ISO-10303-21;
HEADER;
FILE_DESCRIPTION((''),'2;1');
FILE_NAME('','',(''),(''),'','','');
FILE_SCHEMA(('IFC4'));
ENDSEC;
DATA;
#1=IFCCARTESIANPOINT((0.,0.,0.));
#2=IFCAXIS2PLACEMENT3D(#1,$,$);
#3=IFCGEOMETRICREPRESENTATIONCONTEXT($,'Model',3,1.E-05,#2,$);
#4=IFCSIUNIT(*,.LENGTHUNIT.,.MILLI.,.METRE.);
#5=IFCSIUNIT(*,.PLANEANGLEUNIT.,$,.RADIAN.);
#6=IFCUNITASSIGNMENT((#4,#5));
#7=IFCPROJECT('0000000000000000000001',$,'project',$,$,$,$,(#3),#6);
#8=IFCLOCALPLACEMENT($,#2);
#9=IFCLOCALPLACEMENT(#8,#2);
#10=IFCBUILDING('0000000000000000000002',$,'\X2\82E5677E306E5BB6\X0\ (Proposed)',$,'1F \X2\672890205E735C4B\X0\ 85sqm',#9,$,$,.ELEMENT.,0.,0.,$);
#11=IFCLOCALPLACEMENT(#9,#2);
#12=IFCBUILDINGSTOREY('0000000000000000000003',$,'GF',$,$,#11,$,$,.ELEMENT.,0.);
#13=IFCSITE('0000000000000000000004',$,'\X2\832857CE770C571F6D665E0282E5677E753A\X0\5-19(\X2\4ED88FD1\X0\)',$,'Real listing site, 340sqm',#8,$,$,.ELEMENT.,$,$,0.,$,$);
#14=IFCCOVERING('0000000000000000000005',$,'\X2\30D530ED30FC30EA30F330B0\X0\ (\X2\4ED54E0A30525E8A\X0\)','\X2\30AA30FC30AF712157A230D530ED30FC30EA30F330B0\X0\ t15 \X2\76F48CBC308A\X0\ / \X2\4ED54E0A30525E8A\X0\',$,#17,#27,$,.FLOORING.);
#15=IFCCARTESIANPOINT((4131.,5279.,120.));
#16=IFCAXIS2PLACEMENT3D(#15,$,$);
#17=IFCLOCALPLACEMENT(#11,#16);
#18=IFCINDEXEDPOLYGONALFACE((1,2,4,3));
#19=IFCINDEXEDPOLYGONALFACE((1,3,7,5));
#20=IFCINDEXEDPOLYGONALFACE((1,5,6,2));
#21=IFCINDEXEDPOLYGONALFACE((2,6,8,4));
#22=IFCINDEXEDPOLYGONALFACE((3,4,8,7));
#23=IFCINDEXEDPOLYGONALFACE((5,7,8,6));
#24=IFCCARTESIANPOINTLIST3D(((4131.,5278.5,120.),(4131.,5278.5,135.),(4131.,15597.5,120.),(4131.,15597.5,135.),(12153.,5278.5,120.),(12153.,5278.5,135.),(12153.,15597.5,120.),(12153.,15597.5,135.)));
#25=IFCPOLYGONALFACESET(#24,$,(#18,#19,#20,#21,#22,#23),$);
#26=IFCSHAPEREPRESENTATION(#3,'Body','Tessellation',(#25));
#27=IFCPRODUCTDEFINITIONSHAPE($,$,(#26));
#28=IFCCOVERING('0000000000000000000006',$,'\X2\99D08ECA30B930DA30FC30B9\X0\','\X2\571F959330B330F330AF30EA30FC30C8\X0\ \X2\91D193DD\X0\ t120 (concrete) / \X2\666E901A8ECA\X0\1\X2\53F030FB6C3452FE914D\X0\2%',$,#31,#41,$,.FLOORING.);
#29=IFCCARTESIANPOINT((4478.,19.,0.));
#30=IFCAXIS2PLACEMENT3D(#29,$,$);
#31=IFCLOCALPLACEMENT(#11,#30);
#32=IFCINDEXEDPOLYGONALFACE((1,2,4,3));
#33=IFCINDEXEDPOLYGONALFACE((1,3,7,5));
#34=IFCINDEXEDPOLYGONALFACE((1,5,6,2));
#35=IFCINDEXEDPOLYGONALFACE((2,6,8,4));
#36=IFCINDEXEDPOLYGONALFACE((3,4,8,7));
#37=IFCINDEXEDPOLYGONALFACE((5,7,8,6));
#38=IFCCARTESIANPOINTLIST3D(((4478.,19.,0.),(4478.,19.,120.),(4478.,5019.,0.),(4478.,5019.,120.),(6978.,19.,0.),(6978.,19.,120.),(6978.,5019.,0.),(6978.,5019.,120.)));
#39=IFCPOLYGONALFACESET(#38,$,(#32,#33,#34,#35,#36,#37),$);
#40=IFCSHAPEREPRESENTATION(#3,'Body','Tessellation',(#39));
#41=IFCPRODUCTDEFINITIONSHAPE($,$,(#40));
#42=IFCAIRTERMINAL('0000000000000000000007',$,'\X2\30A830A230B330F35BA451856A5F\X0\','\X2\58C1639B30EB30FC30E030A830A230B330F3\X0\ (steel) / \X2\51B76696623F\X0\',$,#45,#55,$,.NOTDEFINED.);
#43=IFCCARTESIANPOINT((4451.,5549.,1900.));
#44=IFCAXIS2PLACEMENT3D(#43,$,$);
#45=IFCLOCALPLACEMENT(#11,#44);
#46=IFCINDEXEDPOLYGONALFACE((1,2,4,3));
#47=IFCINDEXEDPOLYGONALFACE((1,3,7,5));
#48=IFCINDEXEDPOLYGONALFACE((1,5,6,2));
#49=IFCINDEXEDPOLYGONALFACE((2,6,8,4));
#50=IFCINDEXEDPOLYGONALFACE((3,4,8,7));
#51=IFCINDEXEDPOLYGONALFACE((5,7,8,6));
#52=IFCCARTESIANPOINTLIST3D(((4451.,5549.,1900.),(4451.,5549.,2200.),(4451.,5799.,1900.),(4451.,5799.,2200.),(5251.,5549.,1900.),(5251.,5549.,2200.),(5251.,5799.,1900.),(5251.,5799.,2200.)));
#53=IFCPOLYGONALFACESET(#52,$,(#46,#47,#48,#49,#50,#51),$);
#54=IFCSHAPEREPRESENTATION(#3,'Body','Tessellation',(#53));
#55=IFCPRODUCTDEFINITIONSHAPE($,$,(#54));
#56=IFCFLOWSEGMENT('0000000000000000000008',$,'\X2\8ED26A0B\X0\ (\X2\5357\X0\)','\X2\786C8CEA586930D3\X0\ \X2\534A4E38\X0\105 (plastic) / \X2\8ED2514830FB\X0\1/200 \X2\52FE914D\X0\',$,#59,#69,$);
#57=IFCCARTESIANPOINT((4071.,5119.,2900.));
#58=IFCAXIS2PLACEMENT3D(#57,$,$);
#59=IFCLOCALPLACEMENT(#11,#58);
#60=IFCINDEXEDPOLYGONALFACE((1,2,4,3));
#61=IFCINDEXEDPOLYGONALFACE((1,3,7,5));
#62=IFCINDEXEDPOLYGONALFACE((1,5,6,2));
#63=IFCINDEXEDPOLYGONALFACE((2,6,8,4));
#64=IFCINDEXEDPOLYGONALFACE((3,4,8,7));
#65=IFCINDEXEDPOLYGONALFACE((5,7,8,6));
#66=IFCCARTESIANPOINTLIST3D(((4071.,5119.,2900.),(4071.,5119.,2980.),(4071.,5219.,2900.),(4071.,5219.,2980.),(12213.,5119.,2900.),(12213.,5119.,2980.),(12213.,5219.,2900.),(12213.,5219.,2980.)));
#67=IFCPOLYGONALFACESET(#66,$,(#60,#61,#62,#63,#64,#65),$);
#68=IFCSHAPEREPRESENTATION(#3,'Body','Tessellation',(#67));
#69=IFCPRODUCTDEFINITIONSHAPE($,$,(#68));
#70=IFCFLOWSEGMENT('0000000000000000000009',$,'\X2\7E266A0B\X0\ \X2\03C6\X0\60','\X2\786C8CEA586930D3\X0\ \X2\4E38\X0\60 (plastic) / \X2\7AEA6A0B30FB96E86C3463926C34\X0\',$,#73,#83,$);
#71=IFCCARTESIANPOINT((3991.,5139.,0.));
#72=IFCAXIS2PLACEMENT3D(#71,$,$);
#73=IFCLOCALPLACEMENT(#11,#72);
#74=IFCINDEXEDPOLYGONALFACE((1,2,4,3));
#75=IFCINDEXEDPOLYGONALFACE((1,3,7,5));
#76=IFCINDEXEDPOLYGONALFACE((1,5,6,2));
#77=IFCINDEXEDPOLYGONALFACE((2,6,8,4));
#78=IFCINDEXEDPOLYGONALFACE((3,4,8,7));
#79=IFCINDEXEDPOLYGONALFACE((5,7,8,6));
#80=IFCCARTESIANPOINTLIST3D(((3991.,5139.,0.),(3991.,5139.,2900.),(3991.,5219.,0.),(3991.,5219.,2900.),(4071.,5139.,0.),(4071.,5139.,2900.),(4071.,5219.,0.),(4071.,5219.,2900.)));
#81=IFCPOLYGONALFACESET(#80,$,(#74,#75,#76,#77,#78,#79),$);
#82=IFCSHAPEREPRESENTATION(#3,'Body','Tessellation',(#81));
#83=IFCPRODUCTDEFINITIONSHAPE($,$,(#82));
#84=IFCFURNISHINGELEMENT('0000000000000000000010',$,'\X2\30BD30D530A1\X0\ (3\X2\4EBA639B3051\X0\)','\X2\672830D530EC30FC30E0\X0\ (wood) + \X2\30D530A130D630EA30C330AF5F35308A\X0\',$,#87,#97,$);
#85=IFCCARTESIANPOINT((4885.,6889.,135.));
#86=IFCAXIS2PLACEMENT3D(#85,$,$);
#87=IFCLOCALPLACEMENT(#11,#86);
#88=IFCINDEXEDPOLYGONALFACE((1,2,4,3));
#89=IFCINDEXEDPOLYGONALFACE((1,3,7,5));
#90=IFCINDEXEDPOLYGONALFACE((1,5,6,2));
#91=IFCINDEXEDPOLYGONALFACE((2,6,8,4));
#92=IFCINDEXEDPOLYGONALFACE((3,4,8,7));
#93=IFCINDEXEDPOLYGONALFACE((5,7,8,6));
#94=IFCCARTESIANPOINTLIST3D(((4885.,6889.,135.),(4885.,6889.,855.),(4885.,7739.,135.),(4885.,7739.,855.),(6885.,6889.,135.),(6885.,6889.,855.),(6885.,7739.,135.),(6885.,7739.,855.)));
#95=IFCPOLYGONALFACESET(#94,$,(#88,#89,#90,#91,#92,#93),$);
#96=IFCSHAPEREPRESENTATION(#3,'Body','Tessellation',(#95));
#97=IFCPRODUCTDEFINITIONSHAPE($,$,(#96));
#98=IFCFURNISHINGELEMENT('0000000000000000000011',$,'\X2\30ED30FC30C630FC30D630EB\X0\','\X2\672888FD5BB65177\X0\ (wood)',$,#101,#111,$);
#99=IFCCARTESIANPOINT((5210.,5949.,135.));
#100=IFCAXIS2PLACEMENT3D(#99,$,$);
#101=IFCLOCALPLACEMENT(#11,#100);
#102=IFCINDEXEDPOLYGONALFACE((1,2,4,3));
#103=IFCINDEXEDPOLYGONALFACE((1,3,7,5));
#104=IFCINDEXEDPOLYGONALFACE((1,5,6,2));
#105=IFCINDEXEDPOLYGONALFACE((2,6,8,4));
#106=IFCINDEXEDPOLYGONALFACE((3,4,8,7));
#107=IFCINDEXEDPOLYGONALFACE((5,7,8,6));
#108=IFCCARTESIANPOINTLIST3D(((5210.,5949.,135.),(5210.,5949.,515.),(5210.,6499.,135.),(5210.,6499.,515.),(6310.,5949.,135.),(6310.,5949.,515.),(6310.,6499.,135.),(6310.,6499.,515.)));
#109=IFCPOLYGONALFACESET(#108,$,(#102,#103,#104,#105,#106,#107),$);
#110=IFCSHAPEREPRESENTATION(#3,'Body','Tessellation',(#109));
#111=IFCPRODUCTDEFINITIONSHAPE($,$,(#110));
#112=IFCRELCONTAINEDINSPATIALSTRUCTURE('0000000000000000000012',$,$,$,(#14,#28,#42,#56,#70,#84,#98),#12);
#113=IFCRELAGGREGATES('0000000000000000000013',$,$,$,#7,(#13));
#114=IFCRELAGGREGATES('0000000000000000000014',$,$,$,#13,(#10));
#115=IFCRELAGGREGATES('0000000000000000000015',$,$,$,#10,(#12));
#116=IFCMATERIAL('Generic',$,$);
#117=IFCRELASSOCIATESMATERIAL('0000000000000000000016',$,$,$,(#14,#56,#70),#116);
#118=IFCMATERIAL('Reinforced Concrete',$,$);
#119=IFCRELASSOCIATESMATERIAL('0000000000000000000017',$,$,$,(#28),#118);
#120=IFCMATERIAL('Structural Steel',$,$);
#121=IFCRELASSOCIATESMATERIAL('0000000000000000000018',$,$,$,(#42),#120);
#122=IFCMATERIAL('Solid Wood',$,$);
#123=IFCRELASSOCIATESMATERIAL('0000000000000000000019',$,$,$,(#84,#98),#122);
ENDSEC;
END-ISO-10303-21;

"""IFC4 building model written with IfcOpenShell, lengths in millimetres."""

from ifc_helpers import new_model, si_unit, frame, frame_2d, origin, place, context, project, spatial, rectangle, extrude, material, element, save


model = new_model("IFC4")

# Units and contexts
model_context = context("Model", 3, precision=1e-05, world=origin())
ifc_project = project(units=[si_unit("LENGTHUNIT", "METRE", prefix="MILLI"), si_unit("PLANEANGLEUNIT", "RADIAN")], contexts=[model_context])

# Site, building, storey
site_placement = place(None, origin())
site = spatial("IfcSite", under=ifc_project, at=site_placement, Name="茨城県土浦市若松町5-19(付近)", ObjectType="Real listing site, 340sqm", CompositionType="ELEMENT", RefElevation=0.0)
building_placement = place(site_placement, origin())
building = spatial("IfcBuilding", under=site, at=building_placement, Name="若松の家 (Proposed)", ObjectType="1F 木造平屋 85sqm", CompositionType="ELEMENT", ElevationOfRefHeight=0.0, ElevationOfTerrain=0.0)
storey_placement = place(building_placement, origin())
storey = spatial("IfcBuildingStorey", under=building, at=storey_placement, Name="GF", CompositionType="ELEMENT", Elevation=0.0)

# Shared definitions
ifc_material_1 = material(Name="Solid Wood")

# Shared definitions
ifc_material_2 = material(Name="Reinforced Concrete")

# Shared definitions
ifc_material_3 = material(Name="Structural Steel")

# Coverings
ifc_material_4 = material(Name="Generic")
covering_1_placement = place(storey_placement, frame((4131.0, 5279.0, 120.0)))
element("IfcCovering", 1, at=covering_1_placement, inside=storey, material=ifc_material_4, Name="フローリング (仕上げ床)", Description="オーク無垢フローリング t15 直貼り / 仕上げ床", PredefinedType="FLOORING", context=model_context, shape_type="SweptSolid", body=[
    extrude(rectangle(XDim=8022.0, YDim=10319.0, at=frame_2d((4011.0, 5159.0))), frame((4131.0, 5279.0, 120.0)), (0.0, 0.0, 1.0), 15.0),
])
covering_2_placement = place(storey_placement, frame((4478.0, 19.0, 0.0)))
element("IfcCovering", 2, at=covering_2_placement, inside=storey, material=ifc_material_2, Name="駐車スペース", Description="土間コンクリート 金鏝 t120 (concrete) / 普通車1台・水勾配2%", PredefinedType="FLOORING", context=model_context, shape_type="SweptSolid", body=[
    extrude(rectangle(XDim=2500.0, YDim=5000.0, at=frame_2d((1250.0, 2500.0))), frame((4478.0, 19.0, 0.0)), (0.0, 0.0, 1.0), 120.0),
])

# Air terminal
air_terminal_placement = place(storey_placement, frame((4451.0, 5549.0, 1900.0)))
element("IfcAirTerminal", 3, at=air_terminal_placement, inside=storey, material=ifc_material_3, Name="エアコン室内機", Description="壁掛ルームエアコン (steel) / 冷暖房", PredefinedType="NOTDEFINED", context=model_context, shape_type="SweptSolid", body=[
    extrude(rectangle(XDim=800.0, YDim=250.0, at=frame_2d((400.0, 125.0))), frame((4451.0, 5549.0, 1900.0)), (0.0, 0.0, 1.0), 300.0),
])

# Flow segments
flow_segment_1_placement = place(storey_placement, frame((4071.0, 5119.0, 2900.0)))
element("IfcFlowSegment", 4, at=flow_segment_1_placement, inside=storey, material=ifc_material_4, Name="軒樋 (南)", Description="硬質塩ビ 半丸105 (plastic) / 軒先・1/200 勾配", context=model_context, shape_type="SweptSolid", body=[
    extrude(rectangle(XDim=8142.0, YDim=100.0, at=frame_2d((4071.0, 50.0))), frame((4071.0, 5119.0, 2900.0)), (0.0, 0.0, 1.0), 80.0),
])
flow_segment_2_placement = place(storey_placement, frame((3991.0, 5139.0, 0.0)))
element("IfcFlowSegment", 5, at=flow_segment_2_placement, inside=storey, material=ifc_material_4, Name="縦樋 φ60", Description="硬質塩ビ 丸60 (plastic) / 竪樋・雨水排水", context=model_context, shape_type="SweptSolid", body=[
    extrude(rectangle(XDim=80.0, YDim=80.0, at=frame_2d((40.0, 40.0))), frame((3991.0, 5139.0, 0.0)), (0.0, 0.0, 1.0), 2900.0),
])

# Furnishing elements
furnishing_1_placement = place(storey_placement, frame((4885.0, 6889.0, 135.0)))
element("IfcFurnishingElement", 6, at=furnishing_1_placement, inside=storey, material=ifc_material_1, Name="ソファ (3人掛け)", Description="木フレーム (wood) + ファブリック張り", context=model_context, shape_type="SweptSolid", body=[
    extrude(rectangle(XDim=2000.0, YDim=850.0, at=frame_2d((1000.0, 425.0))), frame((4885.0, 6889.0, 135.0)), (0.0, 0.0, 1.0), 720.0),
])
furnishing_2_placement = place(storey_placement, frame((5210.0, 5949.0, 135.0)))
element("IfcFurnishingElement", 7, at=furnishing_2_placement, inside=storey, material=ifc_material_1, Name="ローテーブル", Description="木製家具 (wood)", context=model_context, shape_type="SweptSolid", body=[
    extrude(rectangle(XDim=1100.0, YDim=550.0, at=frame_2d((550.0, 275.0))), frame((5210.0, 5949.0, 135.0)), (0.0, 0.0, 1.0), 380.0),
])

save(model, "model.ifc")
